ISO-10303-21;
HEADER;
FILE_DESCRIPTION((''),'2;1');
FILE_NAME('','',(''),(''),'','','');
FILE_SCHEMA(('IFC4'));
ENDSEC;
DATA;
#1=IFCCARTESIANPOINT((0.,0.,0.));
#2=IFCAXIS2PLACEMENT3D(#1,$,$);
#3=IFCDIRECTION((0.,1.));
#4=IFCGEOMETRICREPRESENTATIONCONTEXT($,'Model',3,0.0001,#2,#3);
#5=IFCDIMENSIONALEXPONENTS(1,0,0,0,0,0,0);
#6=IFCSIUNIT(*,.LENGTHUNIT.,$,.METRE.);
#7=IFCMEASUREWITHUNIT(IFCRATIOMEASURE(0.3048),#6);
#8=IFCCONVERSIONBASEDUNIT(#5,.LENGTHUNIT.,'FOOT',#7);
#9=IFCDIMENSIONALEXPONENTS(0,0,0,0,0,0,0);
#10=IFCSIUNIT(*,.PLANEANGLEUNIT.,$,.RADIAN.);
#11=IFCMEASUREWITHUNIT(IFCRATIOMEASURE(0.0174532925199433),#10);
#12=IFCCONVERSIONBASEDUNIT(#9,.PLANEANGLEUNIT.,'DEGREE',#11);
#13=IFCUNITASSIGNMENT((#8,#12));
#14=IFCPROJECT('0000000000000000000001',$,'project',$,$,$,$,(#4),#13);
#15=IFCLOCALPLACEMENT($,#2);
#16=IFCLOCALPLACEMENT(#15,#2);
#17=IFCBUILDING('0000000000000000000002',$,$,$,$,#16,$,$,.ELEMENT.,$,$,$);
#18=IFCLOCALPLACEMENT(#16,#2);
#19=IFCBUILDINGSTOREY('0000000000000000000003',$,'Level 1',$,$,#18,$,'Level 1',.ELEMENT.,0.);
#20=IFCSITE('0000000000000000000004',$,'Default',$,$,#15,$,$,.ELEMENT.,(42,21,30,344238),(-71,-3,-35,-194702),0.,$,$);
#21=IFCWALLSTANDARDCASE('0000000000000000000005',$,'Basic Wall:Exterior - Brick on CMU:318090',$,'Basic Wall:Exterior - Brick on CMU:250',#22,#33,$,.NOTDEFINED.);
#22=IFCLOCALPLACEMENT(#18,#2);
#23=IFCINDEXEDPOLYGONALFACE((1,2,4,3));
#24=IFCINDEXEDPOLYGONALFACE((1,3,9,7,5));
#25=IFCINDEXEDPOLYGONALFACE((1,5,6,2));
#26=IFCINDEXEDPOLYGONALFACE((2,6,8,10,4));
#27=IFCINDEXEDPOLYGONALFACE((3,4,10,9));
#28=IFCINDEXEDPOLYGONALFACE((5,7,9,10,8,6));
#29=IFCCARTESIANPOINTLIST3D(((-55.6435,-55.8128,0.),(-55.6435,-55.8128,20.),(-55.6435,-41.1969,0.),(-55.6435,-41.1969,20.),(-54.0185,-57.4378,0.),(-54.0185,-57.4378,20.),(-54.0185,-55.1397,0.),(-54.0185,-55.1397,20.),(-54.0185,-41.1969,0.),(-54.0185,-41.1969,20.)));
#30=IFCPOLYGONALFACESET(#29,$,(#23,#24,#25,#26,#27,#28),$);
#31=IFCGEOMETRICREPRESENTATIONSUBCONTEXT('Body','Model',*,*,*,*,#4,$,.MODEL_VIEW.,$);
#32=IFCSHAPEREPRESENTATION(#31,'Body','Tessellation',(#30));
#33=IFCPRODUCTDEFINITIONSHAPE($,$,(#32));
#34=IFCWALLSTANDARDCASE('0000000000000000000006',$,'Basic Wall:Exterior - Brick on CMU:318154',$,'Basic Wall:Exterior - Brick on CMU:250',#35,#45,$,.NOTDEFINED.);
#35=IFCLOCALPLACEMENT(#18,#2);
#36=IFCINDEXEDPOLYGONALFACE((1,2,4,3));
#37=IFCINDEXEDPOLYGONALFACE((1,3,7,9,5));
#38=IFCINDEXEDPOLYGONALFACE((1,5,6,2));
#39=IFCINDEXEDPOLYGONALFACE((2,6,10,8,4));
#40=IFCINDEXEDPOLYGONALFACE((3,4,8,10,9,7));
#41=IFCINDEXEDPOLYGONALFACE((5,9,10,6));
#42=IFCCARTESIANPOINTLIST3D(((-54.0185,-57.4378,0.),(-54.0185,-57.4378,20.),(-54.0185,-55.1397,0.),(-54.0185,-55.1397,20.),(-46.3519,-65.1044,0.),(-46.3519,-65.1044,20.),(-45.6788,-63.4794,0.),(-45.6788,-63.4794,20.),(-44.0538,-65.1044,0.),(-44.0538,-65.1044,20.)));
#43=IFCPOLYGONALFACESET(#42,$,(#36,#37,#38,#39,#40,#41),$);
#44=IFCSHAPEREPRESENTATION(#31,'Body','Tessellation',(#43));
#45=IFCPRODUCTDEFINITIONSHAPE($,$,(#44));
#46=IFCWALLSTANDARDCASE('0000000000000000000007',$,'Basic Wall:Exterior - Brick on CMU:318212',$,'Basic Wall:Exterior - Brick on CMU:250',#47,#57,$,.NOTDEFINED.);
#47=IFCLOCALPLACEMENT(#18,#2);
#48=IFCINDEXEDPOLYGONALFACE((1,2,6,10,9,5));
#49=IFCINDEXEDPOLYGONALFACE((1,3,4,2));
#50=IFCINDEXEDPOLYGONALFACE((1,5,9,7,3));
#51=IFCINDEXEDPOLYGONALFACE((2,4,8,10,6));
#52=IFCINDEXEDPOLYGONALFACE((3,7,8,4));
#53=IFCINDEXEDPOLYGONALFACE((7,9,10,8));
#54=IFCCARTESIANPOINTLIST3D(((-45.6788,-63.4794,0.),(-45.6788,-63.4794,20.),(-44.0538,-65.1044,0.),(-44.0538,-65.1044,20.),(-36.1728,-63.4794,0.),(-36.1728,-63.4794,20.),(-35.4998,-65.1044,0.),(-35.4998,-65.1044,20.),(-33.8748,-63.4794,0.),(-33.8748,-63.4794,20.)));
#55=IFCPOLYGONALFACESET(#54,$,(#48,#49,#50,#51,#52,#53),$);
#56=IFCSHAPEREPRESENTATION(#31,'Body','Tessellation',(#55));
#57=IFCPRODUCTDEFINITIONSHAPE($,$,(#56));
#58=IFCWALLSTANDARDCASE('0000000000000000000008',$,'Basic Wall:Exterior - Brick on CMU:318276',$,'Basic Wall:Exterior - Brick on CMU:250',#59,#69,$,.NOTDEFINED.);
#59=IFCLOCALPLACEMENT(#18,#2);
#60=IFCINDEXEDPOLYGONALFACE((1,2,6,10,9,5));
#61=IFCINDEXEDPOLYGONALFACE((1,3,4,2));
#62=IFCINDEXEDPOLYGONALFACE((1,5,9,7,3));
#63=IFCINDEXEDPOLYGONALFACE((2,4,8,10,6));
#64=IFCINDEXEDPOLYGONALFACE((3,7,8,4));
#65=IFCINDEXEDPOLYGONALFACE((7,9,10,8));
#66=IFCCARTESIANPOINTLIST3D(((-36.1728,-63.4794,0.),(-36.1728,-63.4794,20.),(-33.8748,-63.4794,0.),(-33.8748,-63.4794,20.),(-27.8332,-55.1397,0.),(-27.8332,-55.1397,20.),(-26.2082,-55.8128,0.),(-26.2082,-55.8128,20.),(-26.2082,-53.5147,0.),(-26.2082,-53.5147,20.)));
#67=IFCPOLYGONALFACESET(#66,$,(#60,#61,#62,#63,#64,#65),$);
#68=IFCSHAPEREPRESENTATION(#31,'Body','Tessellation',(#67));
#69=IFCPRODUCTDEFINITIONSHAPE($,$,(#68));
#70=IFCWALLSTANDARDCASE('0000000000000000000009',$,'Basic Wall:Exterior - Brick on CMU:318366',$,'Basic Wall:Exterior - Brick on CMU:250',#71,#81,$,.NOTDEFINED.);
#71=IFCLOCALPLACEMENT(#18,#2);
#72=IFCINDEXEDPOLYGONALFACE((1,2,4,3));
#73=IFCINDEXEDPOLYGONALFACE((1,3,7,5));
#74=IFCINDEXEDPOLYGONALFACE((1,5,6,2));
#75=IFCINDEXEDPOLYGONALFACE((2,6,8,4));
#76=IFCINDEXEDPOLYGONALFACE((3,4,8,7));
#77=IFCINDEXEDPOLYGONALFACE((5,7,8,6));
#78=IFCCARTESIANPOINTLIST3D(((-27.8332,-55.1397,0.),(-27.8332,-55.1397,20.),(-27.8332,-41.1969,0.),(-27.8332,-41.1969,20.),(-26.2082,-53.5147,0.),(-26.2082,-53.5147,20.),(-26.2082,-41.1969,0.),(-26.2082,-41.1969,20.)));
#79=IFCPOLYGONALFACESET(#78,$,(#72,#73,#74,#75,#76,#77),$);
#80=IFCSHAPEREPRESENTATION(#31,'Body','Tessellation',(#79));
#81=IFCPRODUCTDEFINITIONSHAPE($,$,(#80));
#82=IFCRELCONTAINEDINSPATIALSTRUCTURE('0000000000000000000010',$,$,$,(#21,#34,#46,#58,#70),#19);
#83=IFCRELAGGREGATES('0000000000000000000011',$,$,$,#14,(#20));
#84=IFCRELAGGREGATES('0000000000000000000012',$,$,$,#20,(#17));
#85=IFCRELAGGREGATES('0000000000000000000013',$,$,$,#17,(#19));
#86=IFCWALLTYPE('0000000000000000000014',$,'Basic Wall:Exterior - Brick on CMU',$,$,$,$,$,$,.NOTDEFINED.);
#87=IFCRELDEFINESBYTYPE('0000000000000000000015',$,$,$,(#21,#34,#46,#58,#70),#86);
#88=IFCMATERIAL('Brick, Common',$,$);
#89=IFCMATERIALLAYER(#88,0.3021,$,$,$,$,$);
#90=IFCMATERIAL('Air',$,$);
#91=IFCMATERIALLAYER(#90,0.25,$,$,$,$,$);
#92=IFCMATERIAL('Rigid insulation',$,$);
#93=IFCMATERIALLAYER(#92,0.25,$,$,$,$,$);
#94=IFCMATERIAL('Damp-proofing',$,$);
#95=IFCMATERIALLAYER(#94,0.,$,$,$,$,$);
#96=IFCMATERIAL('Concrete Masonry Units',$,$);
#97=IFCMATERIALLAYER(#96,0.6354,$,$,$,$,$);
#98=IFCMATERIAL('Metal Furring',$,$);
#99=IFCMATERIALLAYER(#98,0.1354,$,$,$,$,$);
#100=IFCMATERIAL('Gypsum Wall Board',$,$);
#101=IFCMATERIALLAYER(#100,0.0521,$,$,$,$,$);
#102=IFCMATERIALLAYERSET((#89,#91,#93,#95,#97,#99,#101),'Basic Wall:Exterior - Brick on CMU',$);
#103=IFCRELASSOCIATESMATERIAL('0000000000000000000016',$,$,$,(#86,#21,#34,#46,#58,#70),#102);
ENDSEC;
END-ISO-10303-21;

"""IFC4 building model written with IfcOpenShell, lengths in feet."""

from ifc_helpers import new_model, entity, si_unit, converted_unit, direction, frame, origin, place, context, subcontext, project, spatial, polyline, outline, extrude, material, layer, layer_set, layer_usage, type_object, element, save


model = new_model("IFC4")

# Units and contexts
model_context = context("Model", 3, precision=0.0001, world=origin(), true_north=direction((0.0, 1.0)))
body_context = subcontext(model_context, "Body", "Model", "MODEL_VIEW")
ifc_project = project(units=[converted_unit("LENGTHUNIT", "FOOT", entity("IfcRatioMeasure", 0.3048), si_unit("LENGTHUNIT", "METRE"), dimensions=[1, 0, 0, 0, 0, 0, 0]), converted_unit("PLANEANGLEUNIT", "DEGREE", entity("IfcRatioMeasure", 0.0174532925199433), si_unit("PLANEANGLEUNIT", "RADIAN"), dimensions=[0, 0, 0, 0, 0, 0, 0])], contexts=[model_context])

# Site, building, storey
site_placement = place(None, origin())
site = spatial("IfcSite", under=ifc_project, at=site_placement, Name="Default", CompositionType="ELEMENT", RefLatitude=(42, 21, 30, 344238), RefLongitude=(-71, -3, -35, -194702), RefElevation=0.0)
building_placement = place(site_placement, origin())
building = spatial("IfcBuilding", under=site, at=building_placement, CompositionType="ELEMENT")
storey_placement = place(building_placement, origin())
storey = spatial("IfcBuildingStorey", under=building, at=storey_placement, Name="Level 1", LongName="Level 1", CompositionType="ELEMENT", Elevation=0.0)

# Walls
ifc_material_1 = material(Name="Brick, Common")
ifc_layer_1 = layer(ifc_material_1, 0.3021)
ifc_material_2 = material(Name="Air")
ifc_layer_2 = layer(ifc_material_2, 0.25)
ifc_material_3 = material(Name="Rigid insulation")
ifc_layer_3 = layer(ifc_material_3, 0.25)
ifc_material_4 = material(Name="Damp-proofing")
ifc_layer_4 = layer(ifc_material_4, 0.0)
ifc_material_5 = material(Name="Concrete Masonry Units")
ifc_layer_5 = layer(ifc_material_5, 0.6354)
ifc_material_6 = material(Name="Metal Furring")
ifc_layer_6 = layer(ifc_material_6, 0.1354)
ifc_material_7 = material(Name="Gypsum Wall Board")
ifc_layer_7 = layer(ifc_material_7, 0.0521)
ifc_layer_set = layer_set([ifc_layer_1, ifc_layer_2, ifc_layer_3, ifc_layer_4, ifc_layer_5, ifc_layer_6, ifc_layer_7], Name="Basic Wall:Exterior - Brick on CMU")
ifc_layer_usage_1 = layer_usage(ifc_layer_set, "AXIS2", "NEGATIVE", 0.8125)
wall_type = type_object("IfcWallType", Name="Basic Wall:Exterior - Brick on CMU", PredefinedType="NOTDEFINED", material=ifc_layer_set)
wall_1_placement = place(storey_placement, frame((-54.831, -41.1969, 0.0), z_axis=(0.0, 0.0, 1.0), x_axis=(0.0, -1.0, 0.0)))
element("IfcWallStandardCase", 1, at=wall_1_placement, inside=storey, type_object=wall_type, material=ifc_layer_usage_1, Name="Basic Wall:Exterior - Brick on CMU:318090", ObjectType="Basic Wall:Exterior - Brick on CMU:250", PredefinedType="NOTDEFINED", context=body_context, shape_type="SweptSolid", body=[
    extrude(outline(polyline([(14.6159, -0.8125), (16.2409, 0.8125), (13.9428, 0.8125), (0.0, 0.8125), (0.0, -0.8125), (14.6159, -0.8125)])), origin(), (0.0, 0.0, 1.0), 20.0),
])
ifc_layer_usage_2 = layer_usage(ifc_layer_set, "AXIS2", "NEGATIVE", 0.8125)
wall_2_placement = place(storey_placement, frame((-54.593, -55.7142, 0.0), z_axis=(0.0, 0.0, 1.0), x_axis=(0.707107, -0.707107, 0.0)))
element("IfcWallStandardCase", 2, at=wall_2_placement, inside=storey, type_object=wall_type, material=ifc_layer_usage_2, Name="Basic Wall:Exterior - Brick on CMU:318154", ObjectType="Basic Wall:Exterior - Brick on CMU:250", PredefinedType="NOTDEFINED", context=body_context, shape_type="SweptSolid", body=[
    extrude(outline(polyline([(12.4672, -0.8125), (14.0922, 0.8125), (11.7941, 0.8125), (0.0, 0.8125), (1.625, -0.8125), (12.4672, -0.8125)])), origin(), (0.0, 0.0, 1.0), 20.0),
])
ifc_layer_usage_3 = layer_usage(ifc_layer_set, "AXIS2", "NEGATIVE", 0.8125)
wall_3_placement = place(storey_placement, frame((-45.6788, -64.2919, 0.0)))
element("IfcWallStandardCase", 3, at=wall_3_placement, inside=storey, type_object=wall_type, material=ifc_layer_usage_3, Name="Basic Wall:Exterior - Brick on CMU:318212", ObjectType="Basic Wall:Exterior - Brick on CMU:250", PredefinedType="NOTDEFINED", context=body_context, shape_type="SweptSolid", body=[
    extrude(outline(polyline([(10.1791, -0.8125), (11.8041, 0.8125), (9.506, 0.8125), (0.0, 0.8125), (1.625, -0.8125), (10.1791, -0.8125)])), origin(), (0.0, 0.0, 1.0), 20.0),
])
ifc_layer_usage_4 = layer_usage(ifc_layer_set, "AXIS2", "NEGATIVE", 0.8125)
wall_4_placement = place(storey_placement, frame((-35.5983, -64.0539, 0.0), z_axis=(0.0, 0.0, 1.0), x_axis=(0.707107, 0.707107, 0.0)))
element("IfcWallStandardCase", 4, at=wall_4_placement, inside=storey, type_object=wall_type, material=ifc_layer_usage_4, Name="Basic Wall:Exterior - Brick on CMU:318276", ObjectType="Basic Wall:Exterior - Brick on CMU:250", PredefinedType="NOTDEFINED", context=body_context, shape_type="SweptSolid", body=[
    extrude(outline(polyline([(12.4672, -0.8125), (14.0922, 0.8125), (11.7941, 0.8125), (0.0, 0.8125), (1.625, -0.8125), (12.4672, -0.8125)])), origin(), (0.0, 0.0, 1.0), 20.0),
])
ifc_layer_usage_5 = layer_usage(ifc_layer_set, "AXIS2", "NEGATIVE", 0.8125)
wall_5_placement = place(storey_placement, frame((-27.0207, -55.1397, 0.0), z_axis=(0.0, 0.0, 1.0), x_axis=(0.0, 1.0, 0.0)))
element("IfcWallStandardCase", 5, at=wall_5_placement, inside=storey, type_object=wall_type, material=ifc_layer_usage_5, Name="Basic Wall:Exterior - Brick on CMU:318366", ObjectType="Basic Wall:Exterior - Brick on CMU:250", PredefinedType="NOTDEFINED", context=body_context, shape_type="SweptSolid", body=[
    extrude(outline(polyline([(13.9428, -0.8125), (13.9428, 0.8125), (0.0, 0.8125), (1.625, -0.8125), (13.9428, -0.8125)])), origin(), (0.0, 0.0, 1.0), 20.0),
])

save(model, "model.ifc")
